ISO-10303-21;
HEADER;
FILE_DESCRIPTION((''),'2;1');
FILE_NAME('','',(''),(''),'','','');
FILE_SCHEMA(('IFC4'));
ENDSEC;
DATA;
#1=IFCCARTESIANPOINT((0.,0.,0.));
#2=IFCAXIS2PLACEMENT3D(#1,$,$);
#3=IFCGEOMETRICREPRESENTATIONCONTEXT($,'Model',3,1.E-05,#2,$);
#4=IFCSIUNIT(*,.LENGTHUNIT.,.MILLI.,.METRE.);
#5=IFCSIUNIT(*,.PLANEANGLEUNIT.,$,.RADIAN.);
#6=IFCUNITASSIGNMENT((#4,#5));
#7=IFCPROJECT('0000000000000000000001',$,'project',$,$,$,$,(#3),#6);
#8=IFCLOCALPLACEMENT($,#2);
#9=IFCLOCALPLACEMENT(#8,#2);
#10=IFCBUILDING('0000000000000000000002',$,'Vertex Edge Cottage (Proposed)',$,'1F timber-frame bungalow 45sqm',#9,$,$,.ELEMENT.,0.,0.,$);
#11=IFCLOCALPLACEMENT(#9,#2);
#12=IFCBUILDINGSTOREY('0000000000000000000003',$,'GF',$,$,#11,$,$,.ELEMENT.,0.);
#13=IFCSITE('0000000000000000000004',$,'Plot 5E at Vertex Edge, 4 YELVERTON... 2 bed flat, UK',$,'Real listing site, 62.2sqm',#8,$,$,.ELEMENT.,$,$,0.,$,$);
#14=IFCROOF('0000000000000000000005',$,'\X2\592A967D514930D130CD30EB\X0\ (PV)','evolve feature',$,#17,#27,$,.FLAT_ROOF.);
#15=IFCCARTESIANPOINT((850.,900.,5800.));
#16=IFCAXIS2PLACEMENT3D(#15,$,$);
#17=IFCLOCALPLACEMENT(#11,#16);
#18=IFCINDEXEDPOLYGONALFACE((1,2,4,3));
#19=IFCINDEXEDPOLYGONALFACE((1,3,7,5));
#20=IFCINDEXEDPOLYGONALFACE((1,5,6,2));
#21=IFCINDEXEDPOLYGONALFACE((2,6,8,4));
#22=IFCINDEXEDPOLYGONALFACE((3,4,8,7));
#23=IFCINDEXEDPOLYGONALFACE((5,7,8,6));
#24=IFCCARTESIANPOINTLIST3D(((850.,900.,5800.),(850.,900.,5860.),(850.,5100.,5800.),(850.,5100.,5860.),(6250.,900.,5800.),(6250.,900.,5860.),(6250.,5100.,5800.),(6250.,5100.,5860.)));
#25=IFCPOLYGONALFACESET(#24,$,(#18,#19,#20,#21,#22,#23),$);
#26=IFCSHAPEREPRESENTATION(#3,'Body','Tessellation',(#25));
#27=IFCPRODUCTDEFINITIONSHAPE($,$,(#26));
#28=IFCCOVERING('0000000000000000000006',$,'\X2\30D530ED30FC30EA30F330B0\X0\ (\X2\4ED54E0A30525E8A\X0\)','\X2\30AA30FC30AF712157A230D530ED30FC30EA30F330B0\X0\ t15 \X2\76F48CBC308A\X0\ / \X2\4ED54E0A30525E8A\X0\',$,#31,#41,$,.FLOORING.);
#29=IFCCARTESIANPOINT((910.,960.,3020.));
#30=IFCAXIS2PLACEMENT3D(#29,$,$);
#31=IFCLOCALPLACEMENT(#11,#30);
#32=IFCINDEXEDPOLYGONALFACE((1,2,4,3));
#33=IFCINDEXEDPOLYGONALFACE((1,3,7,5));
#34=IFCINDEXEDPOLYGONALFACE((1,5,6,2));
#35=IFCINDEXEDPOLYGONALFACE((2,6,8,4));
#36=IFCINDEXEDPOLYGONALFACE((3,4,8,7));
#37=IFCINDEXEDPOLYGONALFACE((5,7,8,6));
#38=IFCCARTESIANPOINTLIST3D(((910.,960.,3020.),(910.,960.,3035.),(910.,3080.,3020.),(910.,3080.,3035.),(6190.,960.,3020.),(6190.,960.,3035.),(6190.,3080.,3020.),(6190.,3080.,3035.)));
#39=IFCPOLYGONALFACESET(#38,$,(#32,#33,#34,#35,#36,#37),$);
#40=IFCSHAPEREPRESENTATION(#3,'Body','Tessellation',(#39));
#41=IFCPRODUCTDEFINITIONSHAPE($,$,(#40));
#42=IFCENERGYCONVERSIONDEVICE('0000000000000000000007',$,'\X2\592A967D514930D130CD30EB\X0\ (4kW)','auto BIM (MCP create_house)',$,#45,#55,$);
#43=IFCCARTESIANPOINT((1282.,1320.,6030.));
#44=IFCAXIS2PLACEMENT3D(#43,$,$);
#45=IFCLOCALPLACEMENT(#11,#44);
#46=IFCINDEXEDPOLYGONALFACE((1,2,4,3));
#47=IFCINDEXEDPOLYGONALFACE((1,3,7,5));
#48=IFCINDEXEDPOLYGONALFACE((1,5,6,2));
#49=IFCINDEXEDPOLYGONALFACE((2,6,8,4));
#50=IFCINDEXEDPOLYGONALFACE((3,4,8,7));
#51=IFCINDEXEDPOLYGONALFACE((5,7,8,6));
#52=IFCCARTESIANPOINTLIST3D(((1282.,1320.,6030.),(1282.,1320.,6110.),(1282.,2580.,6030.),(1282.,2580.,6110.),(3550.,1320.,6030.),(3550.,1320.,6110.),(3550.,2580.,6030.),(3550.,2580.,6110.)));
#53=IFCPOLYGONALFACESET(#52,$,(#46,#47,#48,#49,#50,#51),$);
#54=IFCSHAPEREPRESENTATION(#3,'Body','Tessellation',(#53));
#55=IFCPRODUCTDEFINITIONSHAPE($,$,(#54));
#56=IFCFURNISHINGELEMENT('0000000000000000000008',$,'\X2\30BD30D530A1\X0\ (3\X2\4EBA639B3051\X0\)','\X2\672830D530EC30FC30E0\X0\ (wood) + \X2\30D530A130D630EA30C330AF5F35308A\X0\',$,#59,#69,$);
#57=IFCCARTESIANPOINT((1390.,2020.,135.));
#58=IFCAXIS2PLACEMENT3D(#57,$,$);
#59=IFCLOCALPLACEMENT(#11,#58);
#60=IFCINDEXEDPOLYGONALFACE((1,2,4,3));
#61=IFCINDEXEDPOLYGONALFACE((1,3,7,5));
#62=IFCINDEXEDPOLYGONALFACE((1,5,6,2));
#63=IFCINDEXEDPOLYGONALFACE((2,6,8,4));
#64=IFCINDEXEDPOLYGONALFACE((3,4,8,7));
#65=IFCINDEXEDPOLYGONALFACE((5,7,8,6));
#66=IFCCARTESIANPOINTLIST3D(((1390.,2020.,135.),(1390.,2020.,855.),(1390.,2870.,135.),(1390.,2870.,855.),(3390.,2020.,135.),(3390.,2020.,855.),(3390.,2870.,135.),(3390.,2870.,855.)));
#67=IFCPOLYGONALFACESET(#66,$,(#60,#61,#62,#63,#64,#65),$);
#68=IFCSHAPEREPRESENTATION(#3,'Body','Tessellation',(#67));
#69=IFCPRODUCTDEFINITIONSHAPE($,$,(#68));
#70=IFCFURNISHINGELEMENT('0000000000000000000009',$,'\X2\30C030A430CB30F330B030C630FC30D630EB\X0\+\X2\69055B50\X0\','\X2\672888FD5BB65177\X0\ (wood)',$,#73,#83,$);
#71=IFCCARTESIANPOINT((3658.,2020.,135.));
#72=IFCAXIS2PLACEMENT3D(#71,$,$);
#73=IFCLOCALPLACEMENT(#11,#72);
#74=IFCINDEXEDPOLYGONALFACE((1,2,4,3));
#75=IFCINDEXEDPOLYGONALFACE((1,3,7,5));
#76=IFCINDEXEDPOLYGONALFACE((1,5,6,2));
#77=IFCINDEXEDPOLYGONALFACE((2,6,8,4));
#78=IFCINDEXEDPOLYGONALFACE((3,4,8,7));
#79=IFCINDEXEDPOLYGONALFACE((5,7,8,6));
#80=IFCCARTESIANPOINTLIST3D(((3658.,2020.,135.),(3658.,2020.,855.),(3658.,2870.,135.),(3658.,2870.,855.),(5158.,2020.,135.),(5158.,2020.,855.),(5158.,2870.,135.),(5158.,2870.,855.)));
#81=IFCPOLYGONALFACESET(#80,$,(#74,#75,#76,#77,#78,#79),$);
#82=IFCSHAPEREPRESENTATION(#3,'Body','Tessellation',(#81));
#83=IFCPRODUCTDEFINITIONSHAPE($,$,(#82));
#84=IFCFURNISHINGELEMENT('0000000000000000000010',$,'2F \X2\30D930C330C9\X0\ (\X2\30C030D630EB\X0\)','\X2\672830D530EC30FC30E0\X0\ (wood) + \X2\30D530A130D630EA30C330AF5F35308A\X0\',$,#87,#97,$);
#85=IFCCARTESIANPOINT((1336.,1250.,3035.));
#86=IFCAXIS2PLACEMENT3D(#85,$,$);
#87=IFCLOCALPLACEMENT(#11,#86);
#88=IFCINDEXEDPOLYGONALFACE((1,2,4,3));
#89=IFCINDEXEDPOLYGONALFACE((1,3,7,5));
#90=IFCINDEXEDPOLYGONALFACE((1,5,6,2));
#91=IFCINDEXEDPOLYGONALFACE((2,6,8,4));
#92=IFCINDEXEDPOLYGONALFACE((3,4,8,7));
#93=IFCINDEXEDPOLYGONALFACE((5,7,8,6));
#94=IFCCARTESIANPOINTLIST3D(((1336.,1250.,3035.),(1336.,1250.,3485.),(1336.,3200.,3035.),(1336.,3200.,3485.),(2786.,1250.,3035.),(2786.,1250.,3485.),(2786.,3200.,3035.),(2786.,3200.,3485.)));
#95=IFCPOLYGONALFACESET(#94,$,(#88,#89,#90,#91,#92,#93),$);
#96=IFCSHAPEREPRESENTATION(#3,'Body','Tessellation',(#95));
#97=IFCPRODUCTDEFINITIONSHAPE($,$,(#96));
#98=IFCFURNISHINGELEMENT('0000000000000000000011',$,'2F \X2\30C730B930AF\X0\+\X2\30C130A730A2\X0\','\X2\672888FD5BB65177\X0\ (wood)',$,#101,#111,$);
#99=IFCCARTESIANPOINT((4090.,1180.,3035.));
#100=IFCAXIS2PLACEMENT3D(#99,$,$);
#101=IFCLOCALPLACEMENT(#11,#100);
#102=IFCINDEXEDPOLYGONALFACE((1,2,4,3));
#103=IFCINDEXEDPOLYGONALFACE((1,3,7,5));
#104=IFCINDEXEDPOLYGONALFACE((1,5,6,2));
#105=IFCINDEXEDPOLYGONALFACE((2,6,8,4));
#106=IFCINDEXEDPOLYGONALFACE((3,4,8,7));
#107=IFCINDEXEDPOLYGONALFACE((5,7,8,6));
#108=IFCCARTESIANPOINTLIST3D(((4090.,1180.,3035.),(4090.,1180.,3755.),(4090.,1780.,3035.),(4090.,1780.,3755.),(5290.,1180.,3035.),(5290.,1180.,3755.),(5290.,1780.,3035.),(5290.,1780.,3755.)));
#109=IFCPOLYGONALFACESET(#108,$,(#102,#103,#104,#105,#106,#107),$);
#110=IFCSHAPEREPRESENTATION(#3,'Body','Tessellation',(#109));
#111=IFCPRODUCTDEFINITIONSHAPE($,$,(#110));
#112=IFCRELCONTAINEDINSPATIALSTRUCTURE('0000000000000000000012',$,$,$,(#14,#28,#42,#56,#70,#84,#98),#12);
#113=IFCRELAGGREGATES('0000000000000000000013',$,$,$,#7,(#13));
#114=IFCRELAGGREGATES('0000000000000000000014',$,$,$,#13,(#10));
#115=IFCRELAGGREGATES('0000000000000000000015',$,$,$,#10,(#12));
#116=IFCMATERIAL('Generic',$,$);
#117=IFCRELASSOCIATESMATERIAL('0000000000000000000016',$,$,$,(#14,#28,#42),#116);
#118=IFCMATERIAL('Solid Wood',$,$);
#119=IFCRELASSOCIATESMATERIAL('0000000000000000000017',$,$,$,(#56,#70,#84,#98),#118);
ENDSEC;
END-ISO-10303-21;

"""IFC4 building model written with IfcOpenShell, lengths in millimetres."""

from ifc_helpers import new_model, si_unit, frame, frame_2d, origin, place, context, project, spatial, rectangle, extrude, material, element, save


model = new_model("IFC4")

# Units and contexts
model_context = context("Model", 3, precision=1e-05, world=origin())
ifc_project = project(units=[si_unit("LENGTHUNIT", "METRE", prefix="MILLI"), si_unit("PLANEANGLEUNIT", "RADIAN")], contexts=[model_context])

# Site, building, storey
site_placement = place(None, origin())
site = spatial("IfcSite", under=ifc_project, at=site_placement, Name="Plot 5E at Vertex Edge, 4 YELVERTON... 2 bed flat, UK", ObjectType="Real listing site, 62.2sqm", CompositionType="ELEMENT", RefElevation=0.0)
building_placement = place(site_placement, origin())
building = spatial("IfcBuilding", under=site, at=building_placement, Name="Vertex Edge Cottage (Proposed)", ObjectType="1F timber-frame bungalow 45sqm", CompositionType="ELEMENT", ElevationOfRefHeight=0.0, ElevationOfTerrain=0.0)
storey_placement = place(building_placement, origin())
storey = spatial("IfcBuildingStorey", under=building, at=storey_placement, Name="GF", CompositionType="ELEMENT", Elevation=0.0)

# Shared definitions
ifc_material_1 = material(Name="Solid Wood")

# Roof
ifc_material_2 = material(Name="Generic")
roof_1_placement = place(storey_placement, frame((850.0, 900.0, 5800.0)))
element("IfcRoof", 1, at=roof_1_placement, inside=storey, material=ifc_material_2, Name="太陽光パネル (PV)", Description="evolve feature", PredefinedType="FLAT_ROOF", context=model_context, shape_type="SweptSolid", body=[
    extrude(rectangle(XDim=5400.0, YDim=4200.0, at=frame_2d((2700.0, 2100.0))), frame((850.0, 900.0, 5800.0)), (0.0, 0.0, 1.0), 60.0),
])

# Covering
covering_placement = place(storey_placement, frame((910.0, 960.0, 3020.0)))
element("IfcCovering", 2, at=covering_placement, inside=storey, material=ifc_material_2, Name="フローリング (仕上げ床)", Description="オーク無垢フローリング t15 直貼り / 仕上げ床", PredefinedType="FLOORING", context=model_context, shape_type="SweptSolid", body=[
    extrude(rectangle(XDim=5280.0, YDim=2120.0, at=frame_2d((2640.0, 1060.0))), frame((910.0, 960.0, 3020.0)), (0.0, 0.0, 1.0), 15.0),
])

# Energy conversion device
energy_conversion_device_placement = place(storey_placement, frame((1282.0, 1320.0, 6030.0)))
element("IfcEnergyConversionDevice", 3, at=energy_conversion_device_placement, inside=storey, material=ifc_material_2, Name="太陽光パネル (4kW)", Description="auto BIM (MCP create_house)", context=model_context, shape_type="SweptSolid", body=[
    extrude(rectangle(XDim=2268.0, YDim=1260.0, at=frame_2d((1134.0, 630.0))), frame((1282.0, 1320.0, 6030.0)), (0.0, 0.0, 1.0), 80.0),
])

# Furnishing elements
furnishing_1_placement = place(storey_placement, frame((1390.0, 2020.0, 135.0)))
element("IfcFurnishingElement", 4, at=furnishing_1_placement, inside=storey, material=ifc_material_1, Name="ソファ (3人掛け)", Description="木フレーム (wood) + ファブリック張り", context=model_context, shape_type="SweptSolid", body=[
    extrude(rectangle(XDim=2000.0, YDim=850.0, at=frame_2d((1000.0, 425.0))), frame((1390.0, 2020.0, 135.0)), (0.0, 0.0, 1.0), 720.0),
])
furnishing_2_placement = place(storey_placement, frame((3658.0, 2020.0, 135.0)))
element("IfcFurnishingElement", 5, at=furnishing_2_placement, inside=storey, material=ifc_material_1, Name="ダイニングテーブル+椅子", Description="木製家具 (wood)", context=model_context, shape_type="SweptSolid", body=[
    extrude(rectangle(XDim=1500.0, YDim=850.0, at=frame_2d((750.0, 425.0))), frame((3658.0, 2020.0, 135.0)), (0.0, 0.0, 1.0), 720.0),
])
furnishing_3_placement = place(storey_placement, frame((1336.0, 1250.0, 3035.0)))
element("IfcFurnishingElement", 6, at=furnishing_3_placement, inside=storey, material=ifc_material_1, Name="2F ベッド (ダブル)", Description="木フレーム (wood) + ファブリック張り", context=model_context, shape_type="SweptSolid", body=[
    extrude(rectangle(XDim=1450.0, YDim=1950.0, at=frame_2d((725.0, 975.0))), frame((1336.0, 1250.0, 3035.0)), (0.0, 0.0, 1.0), 450.0),
])
furnishing_4_placement = place(storey_placement, frame((4090.0, 1180.0, 3035.0)))
element("IfcFurnishingElement", 7, at=furnishing_4_placement, inside=storey, material=ifc_material_1, Name="2F デスク+チェア", Description="木製家具 (wood)", context=model_context, shape_type="SweptSolid", body=[
    extrude(rectangle(XDim=1200.0, YDim=600.0, at=frame_2d((600.0, 300.0))), frame((4090.0, 1180.0, 3035.0)), (0.0, 0.0, 1.0), 720.0),
])

save(model, "model.ifc")
